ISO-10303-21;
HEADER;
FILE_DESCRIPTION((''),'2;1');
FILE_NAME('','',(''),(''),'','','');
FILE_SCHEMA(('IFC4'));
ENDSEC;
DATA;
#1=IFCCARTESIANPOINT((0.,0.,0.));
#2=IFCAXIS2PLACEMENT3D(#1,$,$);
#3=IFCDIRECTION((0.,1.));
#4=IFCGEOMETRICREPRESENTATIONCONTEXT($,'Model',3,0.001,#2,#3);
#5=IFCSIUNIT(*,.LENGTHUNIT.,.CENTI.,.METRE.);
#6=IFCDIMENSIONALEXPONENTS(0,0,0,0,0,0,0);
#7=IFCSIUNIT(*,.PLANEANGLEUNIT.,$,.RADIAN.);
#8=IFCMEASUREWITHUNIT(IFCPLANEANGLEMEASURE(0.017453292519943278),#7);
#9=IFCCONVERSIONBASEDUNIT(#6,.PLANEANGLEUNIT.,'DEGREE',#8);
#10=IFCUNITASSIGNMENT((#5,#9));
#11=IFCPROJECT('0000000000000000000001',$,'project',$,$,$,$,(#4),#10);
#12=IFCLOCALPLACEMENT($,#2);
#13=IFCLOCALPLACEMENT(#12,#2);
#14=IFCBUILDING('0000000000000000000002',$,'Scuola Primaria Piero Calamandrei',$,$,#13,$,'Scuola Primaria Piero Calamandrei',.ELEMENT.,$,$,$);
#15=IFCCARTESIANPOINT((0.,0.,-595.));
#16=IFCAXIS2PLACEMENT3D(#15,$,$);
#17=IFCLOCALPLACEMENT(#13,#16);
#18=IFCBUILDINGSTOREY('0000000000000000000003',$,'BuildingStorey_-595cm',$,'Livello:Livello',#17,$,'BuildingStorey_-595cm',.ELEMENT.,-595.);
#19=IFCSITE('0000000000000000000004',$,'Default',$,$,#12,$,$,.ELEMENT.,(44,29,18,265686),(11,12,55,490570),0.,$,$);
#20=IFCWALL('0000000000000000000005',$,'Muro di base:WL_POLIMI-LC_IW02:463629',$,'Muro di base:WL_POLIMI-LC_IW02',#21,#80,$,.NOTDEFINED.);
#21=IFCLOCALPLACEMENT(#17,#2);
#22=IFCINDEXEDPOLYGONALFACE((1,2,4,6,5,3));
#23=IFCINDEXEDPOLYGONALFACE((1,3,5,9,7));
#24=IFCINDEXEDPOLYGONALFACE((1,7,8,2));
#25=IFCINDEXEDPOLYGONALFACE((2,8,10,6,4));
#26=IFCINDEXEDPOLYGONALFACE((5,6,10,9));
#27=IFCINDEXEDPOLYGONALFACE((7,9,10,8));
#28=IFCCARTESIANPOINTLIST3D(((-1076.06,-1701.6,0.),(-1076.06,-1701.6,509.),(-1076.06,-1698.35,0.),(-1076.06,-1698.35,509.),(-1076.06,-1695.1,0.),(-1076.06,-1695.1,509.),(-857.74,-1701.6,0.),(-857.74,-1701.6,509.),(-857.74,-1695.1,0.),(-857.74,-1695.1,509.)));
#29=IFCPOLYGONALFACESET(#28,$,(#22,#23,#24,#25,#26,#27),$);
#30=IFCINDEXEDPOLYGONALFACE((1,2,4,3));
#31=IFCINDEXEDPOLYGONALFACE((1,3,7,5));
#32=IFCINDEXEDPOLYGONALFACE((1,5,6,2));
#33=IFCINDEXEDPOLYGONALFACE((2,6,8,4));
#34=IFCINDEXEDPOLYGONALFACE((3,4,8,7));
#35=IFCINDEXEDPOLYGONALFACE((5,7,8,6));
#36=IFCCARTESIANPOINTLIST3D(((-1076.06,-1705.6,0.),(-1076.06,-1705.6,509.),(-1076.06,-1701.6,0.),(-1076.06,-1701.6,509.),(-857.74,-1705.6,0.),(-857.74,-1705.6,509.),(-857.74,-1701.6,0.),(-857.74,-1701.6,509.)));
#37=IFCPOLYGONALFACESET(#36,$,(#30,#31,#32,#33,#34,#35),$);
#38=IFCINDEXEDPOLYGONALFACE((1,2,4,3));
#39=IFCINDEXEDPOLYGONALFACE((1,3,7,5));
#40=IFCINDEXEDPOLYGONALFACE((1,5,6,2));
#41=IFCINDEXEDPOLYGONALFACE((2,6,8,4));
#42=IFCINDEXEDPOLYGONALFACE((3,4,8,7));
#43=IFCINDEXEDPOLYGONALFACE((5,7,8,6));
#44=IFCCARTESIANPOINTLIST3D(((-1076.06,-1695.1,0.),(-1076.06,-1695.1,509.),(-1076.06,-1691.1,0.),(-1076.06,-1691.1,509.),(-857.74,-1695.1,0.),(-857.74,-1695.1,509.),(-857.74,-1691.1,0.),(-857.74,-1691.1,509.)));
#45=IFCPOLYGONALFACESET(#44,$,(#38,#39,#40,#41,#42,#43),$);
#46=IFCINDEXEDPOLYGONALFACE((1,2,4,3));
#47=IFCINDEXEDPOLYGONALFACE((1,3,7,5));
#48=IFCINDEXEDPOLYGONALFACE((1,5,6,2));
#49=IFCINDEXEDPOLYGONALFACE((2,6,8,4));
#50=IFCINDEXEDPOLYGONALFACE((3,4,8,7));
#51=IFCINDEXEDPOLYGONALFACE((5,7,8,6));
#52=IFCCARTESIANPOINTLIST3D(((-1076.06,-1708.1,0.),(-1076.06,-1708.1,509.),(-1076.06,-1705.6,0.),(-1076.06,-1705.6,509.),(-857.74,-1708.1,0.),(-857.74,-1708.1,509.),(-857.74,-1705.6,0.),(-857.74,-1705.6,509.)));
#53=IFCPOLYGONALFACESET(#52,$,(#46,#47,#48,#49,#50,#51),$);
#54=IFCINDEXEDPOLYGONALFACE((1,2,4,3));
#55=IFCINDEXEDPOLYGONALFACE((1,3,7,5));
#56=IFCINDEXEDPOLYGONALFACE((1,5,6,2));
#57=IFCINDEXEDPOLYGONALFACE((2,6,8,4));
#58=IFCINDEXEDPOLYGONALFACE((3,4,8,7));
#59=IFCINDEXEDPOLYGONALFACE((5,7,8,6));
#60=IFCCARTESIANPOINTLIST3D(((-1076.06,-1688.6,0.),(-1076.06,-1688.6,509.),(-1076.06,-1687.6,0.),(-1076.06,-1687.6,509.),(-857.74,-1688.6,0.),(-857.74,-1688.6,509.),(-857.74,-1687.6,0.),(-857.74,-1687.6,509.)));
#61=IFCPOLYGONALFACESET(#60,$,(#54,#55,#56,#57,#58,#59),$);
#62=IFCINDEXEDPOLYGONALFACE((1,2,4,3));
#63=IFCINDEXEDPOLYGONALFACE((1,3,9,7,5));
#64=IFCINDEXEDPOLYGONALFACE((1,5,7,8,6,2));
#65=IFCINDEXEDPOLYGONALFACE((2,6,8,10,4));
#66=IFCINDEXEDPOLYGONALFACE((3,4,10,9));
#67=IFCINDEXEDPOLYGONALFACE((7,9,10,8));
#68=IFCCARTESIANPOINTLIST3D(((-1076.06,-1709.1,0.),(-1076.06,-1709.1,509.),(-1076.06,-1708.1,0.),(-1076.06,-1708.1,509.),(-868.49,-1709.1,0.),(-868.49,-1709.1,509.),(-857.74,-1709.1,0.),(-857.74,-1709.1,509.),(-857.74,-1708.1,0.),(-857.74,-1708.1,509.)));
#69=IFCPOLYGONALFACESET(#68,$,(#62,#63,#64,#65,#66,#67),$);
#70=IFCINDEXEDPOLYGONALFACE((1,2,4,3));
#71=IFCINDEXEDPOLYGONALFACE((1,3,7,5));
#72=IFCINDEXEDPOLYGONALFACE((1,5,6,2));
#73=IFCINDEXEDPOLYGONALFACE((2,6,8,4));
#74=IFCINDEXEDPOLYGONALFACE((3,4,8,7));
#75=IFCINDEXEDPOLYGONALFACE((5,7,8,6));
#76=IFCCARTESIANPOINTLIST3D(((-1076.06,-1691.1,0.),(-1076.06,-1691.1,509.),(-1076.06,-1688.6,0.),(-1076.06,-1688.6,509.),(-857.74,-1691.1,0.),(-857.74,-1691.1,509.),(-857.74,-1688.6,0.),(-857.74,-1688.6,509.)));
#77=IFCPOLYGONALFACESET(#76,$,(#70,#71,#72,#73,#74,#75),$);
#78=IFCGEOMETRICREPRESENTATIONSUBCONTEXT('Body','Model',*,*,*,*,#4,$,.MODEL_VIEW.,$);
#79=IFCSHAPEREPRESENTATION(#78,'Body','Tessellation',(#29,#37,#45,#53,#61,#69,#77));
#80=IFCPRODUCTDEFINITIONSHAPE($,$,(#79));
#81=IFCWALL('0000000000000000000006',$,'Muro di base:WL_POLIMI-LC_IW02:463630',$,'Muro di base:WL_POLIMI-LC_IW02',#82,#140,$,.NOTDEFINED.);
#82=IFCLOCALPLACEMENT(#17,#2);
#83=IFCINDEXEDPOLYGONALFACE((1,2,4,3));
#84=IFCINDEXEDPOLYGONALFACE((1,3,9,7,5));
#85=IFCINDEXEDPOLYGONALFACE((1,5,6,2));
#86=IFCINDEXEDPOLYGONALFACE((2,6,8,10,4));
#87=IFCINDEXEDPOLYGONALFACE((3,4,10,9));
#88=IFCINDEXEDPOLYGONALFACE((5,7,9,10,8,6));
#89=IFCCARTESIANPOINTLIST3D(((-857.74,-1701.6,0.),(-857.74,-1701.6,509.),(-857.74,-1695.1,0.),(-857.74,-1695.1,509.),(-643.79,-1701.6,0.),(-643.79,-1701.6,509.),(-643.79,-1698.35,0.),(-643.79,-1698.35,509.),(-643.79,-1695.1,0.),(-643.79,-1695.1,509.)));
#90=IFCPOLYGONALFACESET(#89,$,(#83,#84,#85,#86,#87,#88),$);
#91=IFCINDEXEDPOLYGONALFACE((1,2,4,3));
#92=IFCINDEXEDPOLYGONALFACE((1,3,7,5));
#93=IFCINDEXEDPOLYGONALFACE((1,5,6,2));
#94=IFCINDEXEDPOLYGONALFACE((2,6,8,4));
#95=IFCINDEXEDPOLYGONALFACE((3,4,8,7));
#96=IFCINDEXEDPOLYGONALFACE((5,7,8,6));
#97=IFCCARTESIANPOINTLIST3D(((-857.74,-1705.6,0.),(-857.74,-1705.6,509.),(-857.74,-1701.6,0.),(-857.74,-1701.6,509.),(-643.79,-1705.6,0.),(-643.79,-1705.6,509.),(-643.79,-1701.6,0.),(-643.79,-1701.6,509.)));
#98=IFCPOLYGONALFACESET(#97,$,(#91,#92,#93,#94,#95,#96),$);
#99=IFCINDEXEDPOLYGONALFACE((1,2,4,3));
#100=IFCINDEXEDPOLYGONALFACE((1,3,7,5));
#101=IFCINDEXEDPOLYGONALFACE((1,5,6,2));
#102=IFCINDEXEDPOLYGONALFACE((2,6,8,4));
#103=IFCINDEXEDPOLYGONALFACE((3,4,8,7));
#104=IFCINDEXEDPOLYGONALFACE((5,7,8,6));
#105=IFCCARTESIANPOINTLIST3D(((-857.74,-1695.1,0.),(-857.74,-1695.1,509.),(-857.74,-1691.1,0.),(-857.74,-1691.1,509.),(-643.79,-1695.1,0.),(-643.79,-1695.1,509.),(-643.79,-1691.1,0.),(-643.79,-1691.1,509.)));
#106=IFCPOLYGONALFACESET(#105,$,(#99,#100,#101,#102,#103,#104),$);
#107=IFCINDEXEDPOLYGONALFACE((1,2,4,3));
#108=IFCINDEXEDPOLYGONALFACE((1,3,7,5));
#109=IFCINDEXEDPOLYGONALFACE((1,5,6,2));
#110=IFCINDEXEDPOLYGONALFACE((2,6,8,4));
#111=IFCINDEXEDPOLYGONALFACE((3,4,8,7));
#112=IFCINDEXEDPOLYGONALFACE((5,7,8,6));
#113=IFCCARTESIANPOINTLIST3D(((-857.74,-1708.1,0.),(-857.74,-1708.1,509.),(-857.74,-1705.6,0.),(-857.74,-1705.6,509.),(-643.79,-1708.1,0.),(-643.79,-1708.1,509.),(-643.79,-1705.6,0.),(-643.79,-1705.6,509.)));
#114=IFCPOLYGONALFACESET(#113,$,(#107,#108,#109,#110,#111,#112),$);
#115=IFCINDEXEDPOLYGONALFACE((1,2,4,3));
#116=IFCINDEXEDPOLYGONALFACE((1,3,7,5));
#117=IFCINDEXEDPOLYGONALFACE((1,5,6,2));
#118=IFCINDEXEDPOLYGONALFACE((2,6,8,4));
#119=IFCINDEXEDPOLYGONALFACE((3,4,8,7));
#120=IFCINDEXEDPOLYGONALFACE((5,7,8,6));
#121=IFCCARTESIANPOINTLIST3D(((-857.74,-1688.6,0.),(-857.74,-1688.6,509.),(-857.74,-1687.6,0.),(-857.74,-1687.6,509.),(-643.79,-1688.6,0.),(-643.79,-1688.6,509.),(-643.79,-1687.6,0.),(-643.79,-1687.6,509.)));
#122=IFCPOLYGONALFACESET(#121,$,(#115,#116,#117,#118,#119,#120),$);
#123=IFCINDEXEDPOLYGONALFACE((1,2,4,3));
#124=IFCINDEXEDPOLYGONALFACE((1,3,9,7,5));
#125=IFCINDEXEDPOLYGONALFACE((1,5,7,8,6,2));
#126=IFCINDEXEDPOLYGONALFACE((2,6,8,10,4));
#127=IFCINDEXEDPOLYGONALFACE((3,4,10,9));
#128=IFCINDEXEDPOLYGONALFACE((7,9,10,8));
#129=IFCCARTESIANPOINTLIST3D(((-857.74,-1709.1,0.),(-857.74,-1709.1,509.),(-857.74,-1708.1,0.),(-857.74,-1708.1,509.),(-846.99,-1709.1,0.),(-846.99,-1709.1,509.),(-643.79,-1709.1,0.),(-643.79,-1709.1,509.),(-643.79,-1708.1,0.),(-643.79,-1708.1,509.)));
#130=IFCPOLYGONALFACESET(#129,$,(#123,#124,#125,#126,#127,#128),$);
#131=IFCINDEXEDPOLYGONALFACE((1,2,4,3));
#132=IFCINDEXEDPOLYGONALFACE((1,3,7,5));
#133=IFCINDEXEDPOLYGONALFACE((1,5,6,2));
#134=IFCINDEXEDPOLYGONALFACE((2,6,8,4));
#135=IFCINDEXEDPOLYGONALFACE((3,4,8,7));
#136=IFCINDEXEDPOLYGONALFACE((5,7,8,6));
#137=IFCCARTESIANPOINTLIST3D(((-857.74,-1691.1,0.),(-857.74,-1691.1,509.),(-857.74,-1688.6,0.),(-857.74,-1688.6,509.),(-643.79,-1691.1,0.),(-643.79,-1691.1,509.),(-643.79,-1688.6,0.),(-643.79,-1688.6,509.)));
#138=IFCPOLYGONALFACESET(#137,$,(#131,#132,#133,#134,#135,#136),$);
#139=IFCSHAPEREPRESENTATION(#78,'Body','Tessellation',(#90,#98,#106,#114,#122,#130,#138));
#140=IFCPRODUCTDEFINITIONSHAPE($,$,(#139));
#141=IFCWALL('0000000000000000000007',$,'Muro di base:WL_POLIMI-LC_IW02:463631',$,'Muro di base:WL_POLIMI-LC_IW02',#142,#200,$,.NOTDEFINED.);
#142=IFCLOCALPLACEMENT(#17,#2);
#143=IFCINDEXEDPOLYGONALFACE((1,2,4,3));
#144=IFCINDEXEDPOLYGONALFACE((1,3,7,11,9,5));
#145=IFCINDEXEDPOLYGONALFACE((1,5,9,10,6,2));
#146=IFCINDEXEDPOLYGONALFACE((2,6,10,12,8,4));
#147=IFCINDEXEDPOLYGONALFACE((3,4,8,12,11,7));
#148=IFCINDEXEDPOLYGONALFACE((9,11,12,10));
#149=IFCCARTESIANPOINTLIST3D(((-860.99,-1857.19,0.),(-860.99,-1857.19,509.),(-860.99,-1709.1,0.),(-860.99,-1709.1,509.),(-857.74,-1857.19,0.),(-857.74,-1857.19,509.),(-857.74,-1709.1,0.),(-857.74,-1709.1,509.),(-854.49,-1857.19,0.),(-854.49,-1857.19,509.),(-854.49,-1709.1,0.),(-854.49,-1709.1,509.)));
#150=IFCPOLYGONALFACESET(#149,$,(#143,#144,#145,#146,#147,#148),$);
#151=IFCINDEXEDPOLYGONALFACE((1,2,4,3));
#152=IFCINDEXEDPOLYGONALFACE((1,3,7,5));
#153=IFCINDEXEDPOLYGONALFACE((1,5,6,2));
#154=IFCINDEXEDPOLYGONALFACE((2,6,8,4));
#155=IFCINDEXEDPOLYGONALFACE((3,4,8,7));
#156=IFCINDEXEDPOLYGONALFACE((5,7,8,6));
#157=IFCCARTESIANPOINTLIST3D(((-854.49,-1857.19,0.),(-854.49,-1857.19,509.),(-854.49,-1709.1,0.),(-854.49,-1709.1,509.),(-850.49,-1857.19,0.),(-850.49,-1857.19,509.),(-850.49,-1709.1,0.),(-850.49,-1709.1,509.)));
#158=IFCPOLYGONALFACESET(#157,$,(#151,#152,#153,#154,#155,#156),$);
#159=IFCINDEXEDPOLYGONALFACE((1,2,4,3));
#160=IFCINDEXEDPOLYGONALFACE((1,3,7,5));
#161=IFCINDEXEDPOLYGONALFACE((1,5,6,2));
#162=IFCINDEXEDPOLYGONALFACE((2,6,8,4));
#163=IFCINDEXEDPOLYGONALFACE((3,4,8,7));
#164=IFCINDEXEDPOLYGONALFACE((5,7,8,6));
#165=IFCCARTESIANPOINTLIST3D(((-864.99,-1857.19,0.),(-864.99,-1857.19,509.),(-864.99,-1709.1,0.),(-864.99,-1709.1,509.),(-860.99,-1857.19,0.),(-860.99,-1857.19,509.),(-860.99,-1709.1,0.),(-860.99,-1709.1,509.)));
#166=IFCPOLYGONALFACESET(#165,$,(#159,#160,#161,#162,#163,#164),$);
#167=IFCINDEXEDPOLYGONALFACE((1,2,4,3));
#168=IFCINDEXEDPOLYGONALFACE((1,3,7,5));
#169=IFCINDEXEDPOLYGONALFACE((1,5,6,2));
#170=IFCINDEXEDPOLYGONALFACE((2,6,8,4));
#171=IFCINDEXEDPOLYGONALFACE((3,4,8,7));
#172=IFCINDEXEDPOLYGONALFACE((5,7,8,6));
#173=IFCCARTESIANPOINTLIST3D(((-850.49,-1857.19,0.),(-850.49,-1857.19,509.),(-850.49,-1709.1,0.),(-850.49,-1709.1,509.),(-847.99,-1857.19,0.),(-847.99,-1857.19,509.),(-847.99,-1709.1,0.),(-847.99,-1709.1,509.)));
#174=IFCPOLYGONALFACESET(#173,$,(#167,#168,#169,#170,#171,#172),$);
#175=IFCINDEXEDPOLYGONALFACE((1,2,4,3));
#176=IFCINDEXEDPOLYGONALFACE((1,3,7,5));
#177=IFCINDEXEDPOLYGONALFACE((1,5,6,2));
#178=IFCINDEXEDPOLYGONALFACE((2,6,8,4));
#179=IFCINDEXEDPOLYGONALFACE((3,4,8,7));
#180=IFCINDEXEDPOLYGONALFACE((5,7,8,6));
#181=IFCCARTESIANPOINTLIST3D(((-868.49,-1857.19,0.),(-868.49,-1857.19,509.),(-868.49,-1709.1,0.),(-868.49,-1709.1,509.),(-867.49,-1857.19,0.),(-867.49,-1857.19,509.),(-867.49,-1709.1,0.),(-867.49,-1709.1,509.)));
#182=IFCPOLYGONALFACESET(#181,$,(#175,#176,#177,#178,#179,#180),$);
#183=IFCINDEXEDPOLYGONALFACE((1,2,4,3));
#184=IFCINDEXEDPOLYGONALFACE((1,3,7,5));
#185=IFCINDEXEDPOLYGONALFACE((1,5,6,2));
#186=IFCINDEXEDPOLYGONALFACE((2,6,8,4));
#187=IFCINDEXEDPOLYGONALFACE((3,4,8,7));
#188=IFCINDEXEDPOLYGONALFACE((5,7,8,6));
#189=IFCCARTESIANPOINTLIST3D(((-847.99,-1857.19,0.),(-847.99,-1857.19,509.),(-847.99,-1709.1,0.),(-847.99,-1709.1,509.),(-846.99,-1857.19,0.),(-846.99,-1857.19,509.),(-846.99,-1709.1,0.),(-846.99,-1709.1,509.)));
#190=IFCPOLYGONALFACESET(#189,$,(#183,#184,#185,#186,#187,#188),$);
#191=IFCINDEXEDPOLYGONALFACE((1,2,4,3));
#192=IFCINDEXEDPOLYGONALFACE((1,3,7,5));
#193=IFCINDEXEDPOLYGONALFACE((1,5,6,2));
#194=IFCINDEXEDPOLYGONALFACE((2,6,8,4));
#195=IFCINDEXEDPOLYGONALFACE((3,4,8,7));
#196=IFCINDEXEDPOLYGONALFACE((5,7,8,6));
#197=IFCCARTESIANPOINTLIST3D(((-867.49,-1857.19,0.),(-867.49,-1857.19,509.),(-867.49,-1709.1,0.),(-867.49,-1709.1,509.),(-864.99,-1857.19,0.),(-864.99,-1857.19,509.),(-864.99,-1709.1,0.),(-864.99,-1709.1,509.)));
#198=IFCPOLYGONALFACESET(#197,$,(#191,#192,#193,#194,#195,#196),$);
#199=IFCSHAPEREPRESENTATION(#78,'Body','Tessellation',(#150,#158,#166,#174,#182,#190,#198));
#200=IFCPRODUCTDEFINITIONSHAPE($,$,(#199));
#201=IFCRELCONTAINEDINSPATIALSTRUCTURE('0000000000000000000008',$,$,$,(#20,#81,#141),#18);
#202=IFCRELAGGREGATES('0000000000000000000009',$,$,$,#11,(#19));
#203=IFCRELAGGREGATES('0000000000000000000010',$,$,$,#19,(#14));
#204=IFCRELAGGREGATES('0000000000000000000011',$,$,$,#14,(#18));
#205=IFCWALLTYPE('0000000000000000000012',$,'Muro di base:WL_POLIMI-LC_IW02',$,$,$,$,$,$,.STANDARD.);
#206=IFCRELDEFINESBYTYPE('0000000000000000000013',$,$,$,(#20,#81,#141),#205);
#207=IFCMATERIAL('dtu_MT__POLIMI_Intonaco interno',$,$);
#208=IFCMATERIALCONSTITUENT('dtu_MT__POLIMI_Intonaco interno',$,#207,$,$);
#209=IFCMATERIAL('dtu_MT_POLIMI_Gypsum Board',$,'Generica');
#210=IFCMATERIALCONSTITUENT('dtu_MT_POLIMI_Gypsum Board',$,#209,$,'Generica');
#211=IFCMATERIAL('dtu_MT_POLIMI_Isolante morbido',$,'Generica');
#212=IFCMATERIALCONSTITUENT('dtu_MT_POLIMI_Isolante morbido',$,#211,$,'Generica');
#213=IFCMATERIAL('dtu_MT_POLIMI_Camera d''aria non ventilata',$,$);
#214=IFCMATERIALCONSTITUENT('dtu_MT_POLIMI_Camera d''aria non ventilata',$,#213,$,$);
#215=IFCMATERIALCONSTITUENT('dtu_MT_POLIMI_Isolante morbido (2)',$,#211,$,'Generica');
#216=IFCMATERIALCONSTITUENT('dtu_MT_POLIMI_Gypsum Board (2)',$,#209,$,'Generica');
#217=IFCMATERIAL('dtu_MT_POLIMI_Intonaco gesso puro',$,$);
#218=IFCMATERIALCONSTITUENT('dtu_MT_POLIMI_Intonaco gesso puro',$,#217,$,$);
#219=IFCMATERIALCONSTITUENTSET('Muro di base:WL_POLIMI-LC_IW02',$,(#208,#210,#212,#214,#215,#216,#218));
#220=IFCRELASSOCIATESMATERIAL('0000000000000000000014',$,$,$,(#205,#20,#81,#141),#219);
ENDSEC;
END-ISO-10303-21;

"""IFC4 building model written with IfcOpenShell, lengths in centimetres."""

from ifc_helpers import new_model, entity, si_unit, converted_unit, direction, frame, origin, place, context, subcontext, project, spatial, indexed_curve, outline, extrude, material, constituent, constituent_set, type_object, element, save


model = new_model("IFC4")

# Units and contexts
model_context = context("Model", 3, precision=0.001, world=origin(), true_north=direction((0.0, 1.0)))
body_context = subcontext(model_context, "Body", "Model", "MODEL_VIEW")
ifc_project = project(units=[si_unit("LENGTHUNIT", "METRE", prefix="CENTI"), converted_unit("PLANEANGLEUNIT", "DEGREE", entity("IfcPlaneAngleMeasure", 0.017453292519943278), si_unit("PLANEANGLEUNIT", "RADIAN"), dimensions=[0, 0, 0, 0, 0, 0, 0])], contexts=[model_context])

# Site, building, storey
site_placement = place(None, origin())
site = spatial("IfcSite", under=ifc_project, at=site_placement, Name="Default", CompositionType="ELEMENT", RefLatitude=(44, 29, 18, 265686), RefLongitude=(11, 12, 55, 490570), RefElevation=0.0)
building_placement = place(site_placement, origin())
building = spatial("IfcBuilding", under=site, at=building_placement, Name="Scuola Primaria Piero Calamandrei", LongName="Scuola Primaria Piero Calamandrei", CompositionType="ELEMENT")
storey_placement = place(building_placement, frame((0.0, 0.0, -595.0)))
storey = spatial("IfcBuildingStorey", under=building, at=storey_placement, Name="BuildingStorey_-595cm", ObjectType="Livello:Livello", LongName="BuildingStorey_-595cm", CompositionType="ELEMENT", Elevation=-595.0)

# Shared definitions
ifc_material_1 = material(Name="dtu_MT__POLIMI_Intonaco interno")

# Shared definitions
ifc_constituent_1 = constituent(ifc_material_1, Name="dtu_MT__POLIMI_Intonaco interno")
ifc_material_2 = material(Name="dtu_MT_POLIMI_Gypsum Board", Category="Generica")
ifc_constituent_2 = constituent(ifc_material_2, Name="dtu_MT_POLIMI_Gypsum Board", Category="Generica")
ifc_material_3 = material(Name="dtu_MT_POLIMI_Isolante morbido", Category="Generica")
ifc_constituent_3 = constituent(ifc_material_3, Name="dtu_MT_POLIMI_Isolante morbido", Category="Generica")
ifc_material_4 = material(Name="dtu_MT_POLIMI_Camera d'aria non ventilata")
ifc_constituent_4 = constituent(ifc_material_4, Name="dtu_MT_POLIMI_Camera d'aria non ventilata")
ifc_constituent_5 = constituent(ifc_material_3, Name="dtu_MT_POLIMI_Isolante morbido (2)", Category="Generica")
ifc_constituent_6 = constituent(ifc_material_2, Name="dtu_MT_POLIMI_Gypsum Board (2)", Category="Generica")
ifc_material_5 = material(Name="dtu_MT_POLIMI_Intonaco gesso puro")
ifc_constituent_7 = constituent(ifc_material_5, Name="dtu_MT_POLIMI_Intonaco gesso puro")
ifc_constituent_set_1 = constituent_set(constituents=[ifc_constituent_1, ifc_constituent_2, ifc_constituent_3, ifc_constituent_4, ifc_constituent_5, ifc_constituent_6, ifc_constituent_7], Name="Muro di base:WL_POLIMI-LC_IW02")
wall_type_1 = type_object("IfcWallType", Name="Muro di base:WL_POLIMI-LC_IW02", PredefinedType="STANDARD", material=ifc_constituent_set_1)

# Walls
wall_1_placement = place(storey_placement, frame((-857.74, -1698.35, 0.0), z_axis=(0.0, 0.0, 1.0), x_axis=(-1.0, 0.0, 0.0)))
element("IfcWall", 1, at=wall_1_placement, inside=storey, type_object=wall_type_1, material=ifc_constituent_set_1, Name="Muro di base:WL_POLIMI-LC_IW02:463629", ObjectType="Muro di base:WL_POLIMI-LC_IW02", PredefinedType="NOTDEFINED", context=body_context, shape_type="SweptSolid", body=[
    extrude(outline(indexed_curve([(-130.99, -3.25), (87.33, -3.25), (87.33, 0.0), (87.33, 3.25), (-130.99, 3.25), (-130.99, -3.25)], self_intersect=False)), frame((130.99, 0.0, 0.0)), (0.0, 0.0, 1.0), 509.0),
    extrude(outline(indexed_curve([(-109.16, -2.0), (109.16, -2.0), (109.16, 2.0), (-109.16, 2.0), (-109.16, -2.0)], self_intersect=False)), frame((109.16, 5.25, 0.0)), (0.0, 0.0, 1.0), 509.0),
    extrude(outline(indexed_curve([(-109.16, -2.0), (109.16, -2.0), (109.16, 2.0), (-109.16, 2.0), (-109.16, -2.0)], self_intersect=False)), frame((109.16, -5.25, 0.0)), (0.0, 0.0, 1.0), 509.0),
    extrude(outline(indexed_curve([(-109.16, -1.25), (109.16, -1.25), (109.16, 1.25), (-109.16, 1.25), (-109.16, -1.25)], self_intersect=False)), frame((109.16, 8.5, 0.0)), (0.0, 0.0, 1.0), 509.0),
    extrude(outline(indexed_curve([(-0.5, -109.16), (0.5, -109.16), (0.5, 109.16), (-0.5, 109.16), (-0.5, -109.16)], self_intersect=False)), frame((109.16, -10.25, 0.0), z_axis=(0.0, 0.0, 1.0), x_axis=(0.0, 1.0, 0.0)), (0.0, 0.0, 1.0), 509.0),
    extrude(outline(indexed_curve([(78.73, -0.4), (89.48, -0.4), (89.48, 0.6), (-128.84, 0.6), (-128.84, -0.4), (78.73, -0.4)], self_intersect=False)), frame((89.48, 10.35, 0.0), z_axis=(0.0, 0.0, 1.0), x_axis=(-1.0, 0.0, 0.0)), (0.0, 0.0, 1.0), 509.0),
    extrude(outline(indexed_curve([(-109.16, -1.25), (109.16, -1.25), (109.16, 1.25), (-109.16, 1.25), (-109.16, -1.25)], self_intersect=False)), frame((109.16, -8.5, 0.0)), (0.0, 0.0, 1.0), 509.0),
])
wall_2_placement = place(storey_placement, frame((-643.79, -1698.35, 0.0), z_axis=(0.0, 0.0, 1.0), x_axis=(-1.0, 0.0, 0.0)))
element("IfcWall", 2, at=wall_2_placement, inside=storey, type_object=wall_type_1, material=ifc_constituent_set_1, Name="Muro di base:WL_POLIMI-LC_IW02:463630", ObjectType="Muro di base:WL_POLIMI-LC_IW02", PredefinedType="NOTDEFINED", context=body_context, shape_type="SweptSolid", body=[
    extrude(outline(indexed_curve([(-85.58, -3.25), (128.37, -3.25), (128.37, 3.25), (-85.58, 3.25), (-85.58, 0.0), (-85.58, -3.25)], self_intersect=False)), frame((85.58, 0.0, 0.0)), (0.0, 0.0, 1.0), 509.0),
    extrude(outline(indexed_curve([(-106.98, -2.0), (106.98, -2.0), (106.98, 2.0), (-106.98, 2.0), (-106.98, -2.0)], self_intersect=False)), frame((106.98, 5.25, 0.0)), (0.0, 0.0, 1.0), 509.0),
    extrude(outline(indexed_curve([(-106.98, -2.0), (106.98, -2.0), (106.98, 2.0), (-106.98, 2.0), (-106.98, -2.0)], self_intersect=False)), frame((106.98, -5.25, 0.0)), (0.0, 0.0, 1.0), 509.0),
    extrude(outline(indexed_curve([(-106.98, -1.25), (106.98, -1.25), (106.98, 1.25), (-106.98, 1.25), (-106.98, -1.25)], self_intersect=False)), frame((106.98, 8.5, 0.0)), (0.0, 0.0, 1.0), 509.0),
    extrude(outline(indexed_curve([(-0.5, -106.98), (0.5, -106.98), (0.5, 106.98), (-0.5, 106.98), (-0.5, -106.98)], self_intersect=False)), frame((106.98, -10.25, 0.0), z_axis=(0.0, 0.0, 1.0), x_axis=(0.0, 1.0, 0.0)), (0.0, 0.0, 1.0), 509.0),
    extrude(outline(indexed_curve([(-76.98, -0.4), (126.22, -0.4), (126.22, 0.6), (-87.73, 0.6), (-87.73, -0.4), (-76.98, -0.4)], self_intersect=False)), frame((126.22, 10.35, 0.0), z_axis=(0.0, 0.0, 1.0), x_axis=(-1.0, 0.0, 0.0)), (0.0, 0.0, 1.0), 509.0),
    extrude(outline(indexed_curve([(-106.98, -1.25), (106.98, -1.25), (106.98, 1.25), (-106.98, 1.25), (-106.98, -1.25)], self_intersect=False)), frame((106.98, -8.5, 0.0)), (0.0, 0.0, 1.0), 509.0),
])
wall_3_placement = place(storey_placement, frame((-857.74, -1709.1, 0.0), z_axis=(0.0, 0.0, 1.0), x_axis=(0.0, -1.0, 0.0)))
element("IfcWall", 3, at=wall_3_placement, inside=storey, type_object=wall_type_1, material=ifc_constituent_set_1, Name="Muro di base:WL_POLIMI-LC_IW02:463631", ObjectType="Muro di base:WL_POLIMI-LC_IW02", PredefinedType="NOTDEFINED", context=body_context, shape_type="SweptSolid", body=[
    extrude(outline(indexed_curve([(-74.04, -3.25), (74.04, -3.25), (74.04, 0.0), (74.04, 3.25), (-74.04, 3.25), (-74.04, 0.0), (-74.04, -3.25)], self_intersect=False)), frame((74.04, 0.0, 0.0)), (0.0, 0.0, 1.0), 509.0),
    extrude(outline(indexed_curve([(-74.04, -2.0), (74.04, -2.0), (74.04, 2.0), (-74.04, 2.0), (-74.04, -2.0)], self_intersect=False)), frame((74.04, 5.25, 0.0)), (0.0, 0.0, 1.0), 509.0),
    extrude(outline(indexed_curve([(-74.04, -2.0), (74.04, -2.0), (74.04, 2.0), (-74.04, 2.0), (-74.04, -2.0)], self_intersect=False)), frame((74.04, -5.25, 0.0)), (0.0, 0.0, 1.0), 509.0),
    extrude(outline(indexed_curve([(-74.04, -1.25), (74.04, -1.25), (74.04, 1.25), (-74.04, 1.25), (-74.04, -1.25)], self_intersect=False)), frame((74.04, 8.5, 0.0)), (0.0, 0.0, 1.0), 509.0),
    extrude(outline(indexed_curve([(-0.5, -74.04), (0.5, -74.04), (0.5, 74.04), (-0.5, 74.04), (-0.5, -74.04)], self_intersect=False)), frame((74.04, -10.25, 0.0), z_axis=(0.0, 0.0, 1.0), x_axis=(0.0, 1.0, 0.0)), (0.0, 0.0, 1.0), 509.0),
    extrude(outline(indexed_curve([(-0.5, -74.04), (0.5, -74.04), (0.5, 74.04), (-0.5, 74.04), (-0.5, -74.04)], self_intersect=False)), frame((74.04, 10.25, 0.0), z_axis=(0.0, 0.0, 1.0), x_axis=(0.0, -1.0, 0.0)), (0.0, 0.0, 1.0), 509.0),
    extrude(outline(indexed_curve([(-74.04, -1.25), (74.04, -1.25), (74.04, 1.25), (-74.04, 1.25), (-74.04, -1.25)], self_intersect=False)), frame((74.04, -8.5, 0.0)), (0.0, 0.0, 1.0), 509.0),
])

save(model, "model.ifc")
